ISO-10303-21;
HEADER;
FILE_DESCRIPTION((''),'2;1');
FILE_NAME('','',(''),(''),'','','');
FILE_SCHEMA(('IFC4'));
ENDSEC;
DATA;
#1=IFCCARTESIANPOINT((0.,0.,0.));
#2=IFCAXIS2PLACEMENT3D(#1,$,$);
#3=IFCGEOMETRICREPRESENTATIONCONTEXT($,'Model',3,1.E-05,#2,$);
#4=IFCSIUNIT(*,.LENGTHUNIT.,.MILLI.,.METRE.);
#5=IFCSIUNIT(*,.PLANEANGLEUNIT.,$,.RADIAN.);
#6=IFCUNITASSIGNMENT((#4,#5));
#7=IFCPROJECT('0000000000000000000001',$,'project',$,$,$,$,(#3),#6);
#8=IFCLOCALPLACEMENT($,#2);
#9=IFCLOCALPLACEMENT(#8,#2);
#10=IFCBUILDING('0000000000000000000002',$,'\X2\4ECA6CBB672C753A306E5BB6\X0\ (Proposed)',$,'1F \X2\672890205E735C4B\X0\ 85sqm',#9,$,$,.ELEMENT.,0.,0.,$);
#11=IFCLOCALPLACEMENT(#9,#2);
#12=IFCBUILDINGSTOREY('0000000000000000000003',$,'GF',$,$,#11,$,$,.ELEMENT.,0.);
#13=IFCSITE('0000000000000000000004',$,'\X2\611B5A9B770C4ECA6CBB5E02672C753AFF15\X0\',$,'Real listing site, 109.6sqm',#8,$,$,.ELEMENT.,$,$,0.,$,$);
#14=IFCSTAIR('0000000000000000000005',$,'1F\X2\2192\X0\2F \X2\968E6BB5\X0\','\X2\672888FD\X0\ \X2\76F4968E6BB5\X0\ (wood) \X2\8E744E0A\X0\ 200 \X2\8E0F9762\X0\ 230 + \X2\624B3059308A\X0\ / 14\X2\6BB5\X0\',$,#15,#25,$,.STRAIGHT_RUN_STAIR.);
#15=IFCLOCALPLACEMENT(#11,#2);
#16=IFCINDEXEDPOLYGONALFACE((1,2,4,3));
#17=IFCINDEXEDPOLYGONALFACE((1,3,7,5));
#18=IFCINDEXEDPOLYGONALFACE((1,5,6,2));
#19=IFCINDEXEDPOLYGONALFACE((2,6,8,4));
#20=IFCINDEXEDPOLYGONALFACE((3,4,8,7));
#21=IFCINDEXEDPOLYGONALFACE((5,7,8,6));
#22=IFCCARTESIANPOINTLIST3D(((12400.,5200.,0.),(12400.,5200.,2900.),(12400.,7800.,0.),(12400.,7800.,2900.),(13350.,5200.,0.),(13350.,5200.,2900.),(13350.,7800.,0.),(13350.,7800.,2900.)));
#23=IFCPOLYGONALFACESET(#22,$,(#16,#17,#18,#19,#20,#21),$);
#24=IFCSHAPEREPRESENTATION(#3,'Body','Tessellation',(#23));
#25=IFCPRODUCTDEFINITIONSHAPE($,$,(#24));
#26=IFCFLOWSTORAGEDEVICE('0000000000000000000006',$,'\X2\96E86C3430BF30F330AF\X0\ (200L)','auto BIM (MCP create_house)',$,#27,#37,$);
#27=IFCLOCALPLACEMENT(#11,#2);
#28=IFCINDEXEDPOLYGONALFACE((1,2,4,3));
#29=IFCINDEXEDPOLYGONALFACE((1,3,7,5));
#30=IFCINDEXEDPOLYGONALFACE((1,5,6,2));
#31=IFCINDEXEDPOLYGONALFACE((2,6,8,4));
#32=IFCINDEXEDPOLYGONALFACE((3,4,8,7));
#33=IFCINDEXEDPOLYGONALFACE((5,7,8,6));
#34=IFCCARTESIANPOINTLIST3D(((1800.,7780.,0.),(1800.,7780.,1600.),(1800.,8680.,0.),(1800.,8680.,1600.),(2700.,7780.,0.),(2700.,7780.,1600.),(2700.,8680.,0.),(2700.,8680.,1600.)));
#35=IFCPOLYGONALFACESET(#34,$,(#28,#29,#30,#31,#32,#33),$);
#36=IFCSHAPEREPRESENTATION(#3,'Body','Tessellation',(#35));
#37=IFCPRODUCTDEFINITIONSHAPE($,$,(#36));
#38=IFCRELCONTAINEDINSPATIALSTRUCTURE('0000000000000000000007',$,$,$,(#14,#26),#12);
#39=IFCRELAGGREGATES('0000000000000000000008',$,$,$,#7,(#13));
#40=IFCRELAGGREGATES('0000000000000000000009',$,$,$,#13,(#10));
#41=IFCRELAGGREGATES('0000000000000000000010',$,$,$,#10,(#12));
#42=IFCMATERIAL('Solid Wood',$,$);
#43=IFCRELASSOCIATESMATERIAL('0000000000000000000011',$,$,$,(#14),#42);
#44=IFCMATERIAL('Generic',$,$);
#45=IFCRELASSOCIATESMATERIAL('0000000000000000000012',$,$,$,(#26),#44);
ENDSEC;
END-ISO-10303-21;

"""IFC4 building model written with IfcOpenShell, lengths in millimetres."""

from ifc_helpers import new_model, si_unit, frame, frame_2d, origin, place, context, project, spatial, rectangle, extrude, material, element, save


model = new_model("IFC4")

# Units and contexts
model_context = context("Model", 3, precision=1e-05, world=origin())
ifc_project = project(units=[si_unit("LENGTHUNIT", "METRE", prefix="MILLI"), si_unit("PLANEANGLEUNIT", "RADIAN")], contexts=[model_context])

# Site, building, storey
site_placement = place(None, origin())
site = spatial("IfcSite", under=ifc_project, at=site_placement, Name="愛媛県今治市本町５", ObjectType="Real listing site, 109.6sqm", CompositionType="ELEMENT", RefElevation=0.0)
building_placement = place(site_placement, origin())
building = spatial("IfcBuilding", under=site, at=building_placement, Name="今治本町の家 (Proposed)", ObjectType="1F 木造平屋 85sqm", CompositionType="ELEMENT", ElevationOfRefHeight=0.0, ElevationOfTerrain=0.0)
storey_placement = place(building_placement, origin())
storey = spatial("IfcBuildingStorey", under=building, at=storey_placement, Name="GF", CompositionType="ELEMENT", Elevation=0.0)

# Shared definitions
ifc_material_1 = material(Name="Solid Wood")

# Stair
stair_placement = place(storey_placement, frame((6200.0, 2600.0, 0.0)))
element("IfcStair", 1, at=stair_placement, inside=storey, material=ifc_material_1, Name="1F→2F 階段", Description="木製 直階段 (wood) 蹴上 200 踏面 230 + 手すり / 14段", PredefinedType="STRAIGHT_RUN_STAIR", context=model_context, shape_type="SweptSolid", body=[
    extrude(rectangle(XDim=950.0, YDim=2600.0, at=frame_2d((475.0, 1300.0))), frame((6200.0, 2600.0, 0.0)), (0.0, 0.0, 1.0), 2900.0),
])

# Shared definitions
ifc_material_2 = material(Name="Generic")

# Flow storage device
flow_storage_device_placement = place(storey_placement, frame((900.0, 3890.0, 0.0)))
element("IfcFlowStorageDevice", 2, at=flow_storage_device_placement, inside=storey, material=ifc_material_2, Name="雨水タンク (200L)", Description="auto BIM (MCP create_house)", context=model_context, shape_type="SweptSolid", body=[
    extrude(rectangle(XDim=900.0, YDim=900.0, at=frame_2d((450.0, 450.0))), frame((900.0, 3890.0, 0.0)), (0.0, 0.0, 1.0), 1600.0),
])

save(model, "model.ifc")
